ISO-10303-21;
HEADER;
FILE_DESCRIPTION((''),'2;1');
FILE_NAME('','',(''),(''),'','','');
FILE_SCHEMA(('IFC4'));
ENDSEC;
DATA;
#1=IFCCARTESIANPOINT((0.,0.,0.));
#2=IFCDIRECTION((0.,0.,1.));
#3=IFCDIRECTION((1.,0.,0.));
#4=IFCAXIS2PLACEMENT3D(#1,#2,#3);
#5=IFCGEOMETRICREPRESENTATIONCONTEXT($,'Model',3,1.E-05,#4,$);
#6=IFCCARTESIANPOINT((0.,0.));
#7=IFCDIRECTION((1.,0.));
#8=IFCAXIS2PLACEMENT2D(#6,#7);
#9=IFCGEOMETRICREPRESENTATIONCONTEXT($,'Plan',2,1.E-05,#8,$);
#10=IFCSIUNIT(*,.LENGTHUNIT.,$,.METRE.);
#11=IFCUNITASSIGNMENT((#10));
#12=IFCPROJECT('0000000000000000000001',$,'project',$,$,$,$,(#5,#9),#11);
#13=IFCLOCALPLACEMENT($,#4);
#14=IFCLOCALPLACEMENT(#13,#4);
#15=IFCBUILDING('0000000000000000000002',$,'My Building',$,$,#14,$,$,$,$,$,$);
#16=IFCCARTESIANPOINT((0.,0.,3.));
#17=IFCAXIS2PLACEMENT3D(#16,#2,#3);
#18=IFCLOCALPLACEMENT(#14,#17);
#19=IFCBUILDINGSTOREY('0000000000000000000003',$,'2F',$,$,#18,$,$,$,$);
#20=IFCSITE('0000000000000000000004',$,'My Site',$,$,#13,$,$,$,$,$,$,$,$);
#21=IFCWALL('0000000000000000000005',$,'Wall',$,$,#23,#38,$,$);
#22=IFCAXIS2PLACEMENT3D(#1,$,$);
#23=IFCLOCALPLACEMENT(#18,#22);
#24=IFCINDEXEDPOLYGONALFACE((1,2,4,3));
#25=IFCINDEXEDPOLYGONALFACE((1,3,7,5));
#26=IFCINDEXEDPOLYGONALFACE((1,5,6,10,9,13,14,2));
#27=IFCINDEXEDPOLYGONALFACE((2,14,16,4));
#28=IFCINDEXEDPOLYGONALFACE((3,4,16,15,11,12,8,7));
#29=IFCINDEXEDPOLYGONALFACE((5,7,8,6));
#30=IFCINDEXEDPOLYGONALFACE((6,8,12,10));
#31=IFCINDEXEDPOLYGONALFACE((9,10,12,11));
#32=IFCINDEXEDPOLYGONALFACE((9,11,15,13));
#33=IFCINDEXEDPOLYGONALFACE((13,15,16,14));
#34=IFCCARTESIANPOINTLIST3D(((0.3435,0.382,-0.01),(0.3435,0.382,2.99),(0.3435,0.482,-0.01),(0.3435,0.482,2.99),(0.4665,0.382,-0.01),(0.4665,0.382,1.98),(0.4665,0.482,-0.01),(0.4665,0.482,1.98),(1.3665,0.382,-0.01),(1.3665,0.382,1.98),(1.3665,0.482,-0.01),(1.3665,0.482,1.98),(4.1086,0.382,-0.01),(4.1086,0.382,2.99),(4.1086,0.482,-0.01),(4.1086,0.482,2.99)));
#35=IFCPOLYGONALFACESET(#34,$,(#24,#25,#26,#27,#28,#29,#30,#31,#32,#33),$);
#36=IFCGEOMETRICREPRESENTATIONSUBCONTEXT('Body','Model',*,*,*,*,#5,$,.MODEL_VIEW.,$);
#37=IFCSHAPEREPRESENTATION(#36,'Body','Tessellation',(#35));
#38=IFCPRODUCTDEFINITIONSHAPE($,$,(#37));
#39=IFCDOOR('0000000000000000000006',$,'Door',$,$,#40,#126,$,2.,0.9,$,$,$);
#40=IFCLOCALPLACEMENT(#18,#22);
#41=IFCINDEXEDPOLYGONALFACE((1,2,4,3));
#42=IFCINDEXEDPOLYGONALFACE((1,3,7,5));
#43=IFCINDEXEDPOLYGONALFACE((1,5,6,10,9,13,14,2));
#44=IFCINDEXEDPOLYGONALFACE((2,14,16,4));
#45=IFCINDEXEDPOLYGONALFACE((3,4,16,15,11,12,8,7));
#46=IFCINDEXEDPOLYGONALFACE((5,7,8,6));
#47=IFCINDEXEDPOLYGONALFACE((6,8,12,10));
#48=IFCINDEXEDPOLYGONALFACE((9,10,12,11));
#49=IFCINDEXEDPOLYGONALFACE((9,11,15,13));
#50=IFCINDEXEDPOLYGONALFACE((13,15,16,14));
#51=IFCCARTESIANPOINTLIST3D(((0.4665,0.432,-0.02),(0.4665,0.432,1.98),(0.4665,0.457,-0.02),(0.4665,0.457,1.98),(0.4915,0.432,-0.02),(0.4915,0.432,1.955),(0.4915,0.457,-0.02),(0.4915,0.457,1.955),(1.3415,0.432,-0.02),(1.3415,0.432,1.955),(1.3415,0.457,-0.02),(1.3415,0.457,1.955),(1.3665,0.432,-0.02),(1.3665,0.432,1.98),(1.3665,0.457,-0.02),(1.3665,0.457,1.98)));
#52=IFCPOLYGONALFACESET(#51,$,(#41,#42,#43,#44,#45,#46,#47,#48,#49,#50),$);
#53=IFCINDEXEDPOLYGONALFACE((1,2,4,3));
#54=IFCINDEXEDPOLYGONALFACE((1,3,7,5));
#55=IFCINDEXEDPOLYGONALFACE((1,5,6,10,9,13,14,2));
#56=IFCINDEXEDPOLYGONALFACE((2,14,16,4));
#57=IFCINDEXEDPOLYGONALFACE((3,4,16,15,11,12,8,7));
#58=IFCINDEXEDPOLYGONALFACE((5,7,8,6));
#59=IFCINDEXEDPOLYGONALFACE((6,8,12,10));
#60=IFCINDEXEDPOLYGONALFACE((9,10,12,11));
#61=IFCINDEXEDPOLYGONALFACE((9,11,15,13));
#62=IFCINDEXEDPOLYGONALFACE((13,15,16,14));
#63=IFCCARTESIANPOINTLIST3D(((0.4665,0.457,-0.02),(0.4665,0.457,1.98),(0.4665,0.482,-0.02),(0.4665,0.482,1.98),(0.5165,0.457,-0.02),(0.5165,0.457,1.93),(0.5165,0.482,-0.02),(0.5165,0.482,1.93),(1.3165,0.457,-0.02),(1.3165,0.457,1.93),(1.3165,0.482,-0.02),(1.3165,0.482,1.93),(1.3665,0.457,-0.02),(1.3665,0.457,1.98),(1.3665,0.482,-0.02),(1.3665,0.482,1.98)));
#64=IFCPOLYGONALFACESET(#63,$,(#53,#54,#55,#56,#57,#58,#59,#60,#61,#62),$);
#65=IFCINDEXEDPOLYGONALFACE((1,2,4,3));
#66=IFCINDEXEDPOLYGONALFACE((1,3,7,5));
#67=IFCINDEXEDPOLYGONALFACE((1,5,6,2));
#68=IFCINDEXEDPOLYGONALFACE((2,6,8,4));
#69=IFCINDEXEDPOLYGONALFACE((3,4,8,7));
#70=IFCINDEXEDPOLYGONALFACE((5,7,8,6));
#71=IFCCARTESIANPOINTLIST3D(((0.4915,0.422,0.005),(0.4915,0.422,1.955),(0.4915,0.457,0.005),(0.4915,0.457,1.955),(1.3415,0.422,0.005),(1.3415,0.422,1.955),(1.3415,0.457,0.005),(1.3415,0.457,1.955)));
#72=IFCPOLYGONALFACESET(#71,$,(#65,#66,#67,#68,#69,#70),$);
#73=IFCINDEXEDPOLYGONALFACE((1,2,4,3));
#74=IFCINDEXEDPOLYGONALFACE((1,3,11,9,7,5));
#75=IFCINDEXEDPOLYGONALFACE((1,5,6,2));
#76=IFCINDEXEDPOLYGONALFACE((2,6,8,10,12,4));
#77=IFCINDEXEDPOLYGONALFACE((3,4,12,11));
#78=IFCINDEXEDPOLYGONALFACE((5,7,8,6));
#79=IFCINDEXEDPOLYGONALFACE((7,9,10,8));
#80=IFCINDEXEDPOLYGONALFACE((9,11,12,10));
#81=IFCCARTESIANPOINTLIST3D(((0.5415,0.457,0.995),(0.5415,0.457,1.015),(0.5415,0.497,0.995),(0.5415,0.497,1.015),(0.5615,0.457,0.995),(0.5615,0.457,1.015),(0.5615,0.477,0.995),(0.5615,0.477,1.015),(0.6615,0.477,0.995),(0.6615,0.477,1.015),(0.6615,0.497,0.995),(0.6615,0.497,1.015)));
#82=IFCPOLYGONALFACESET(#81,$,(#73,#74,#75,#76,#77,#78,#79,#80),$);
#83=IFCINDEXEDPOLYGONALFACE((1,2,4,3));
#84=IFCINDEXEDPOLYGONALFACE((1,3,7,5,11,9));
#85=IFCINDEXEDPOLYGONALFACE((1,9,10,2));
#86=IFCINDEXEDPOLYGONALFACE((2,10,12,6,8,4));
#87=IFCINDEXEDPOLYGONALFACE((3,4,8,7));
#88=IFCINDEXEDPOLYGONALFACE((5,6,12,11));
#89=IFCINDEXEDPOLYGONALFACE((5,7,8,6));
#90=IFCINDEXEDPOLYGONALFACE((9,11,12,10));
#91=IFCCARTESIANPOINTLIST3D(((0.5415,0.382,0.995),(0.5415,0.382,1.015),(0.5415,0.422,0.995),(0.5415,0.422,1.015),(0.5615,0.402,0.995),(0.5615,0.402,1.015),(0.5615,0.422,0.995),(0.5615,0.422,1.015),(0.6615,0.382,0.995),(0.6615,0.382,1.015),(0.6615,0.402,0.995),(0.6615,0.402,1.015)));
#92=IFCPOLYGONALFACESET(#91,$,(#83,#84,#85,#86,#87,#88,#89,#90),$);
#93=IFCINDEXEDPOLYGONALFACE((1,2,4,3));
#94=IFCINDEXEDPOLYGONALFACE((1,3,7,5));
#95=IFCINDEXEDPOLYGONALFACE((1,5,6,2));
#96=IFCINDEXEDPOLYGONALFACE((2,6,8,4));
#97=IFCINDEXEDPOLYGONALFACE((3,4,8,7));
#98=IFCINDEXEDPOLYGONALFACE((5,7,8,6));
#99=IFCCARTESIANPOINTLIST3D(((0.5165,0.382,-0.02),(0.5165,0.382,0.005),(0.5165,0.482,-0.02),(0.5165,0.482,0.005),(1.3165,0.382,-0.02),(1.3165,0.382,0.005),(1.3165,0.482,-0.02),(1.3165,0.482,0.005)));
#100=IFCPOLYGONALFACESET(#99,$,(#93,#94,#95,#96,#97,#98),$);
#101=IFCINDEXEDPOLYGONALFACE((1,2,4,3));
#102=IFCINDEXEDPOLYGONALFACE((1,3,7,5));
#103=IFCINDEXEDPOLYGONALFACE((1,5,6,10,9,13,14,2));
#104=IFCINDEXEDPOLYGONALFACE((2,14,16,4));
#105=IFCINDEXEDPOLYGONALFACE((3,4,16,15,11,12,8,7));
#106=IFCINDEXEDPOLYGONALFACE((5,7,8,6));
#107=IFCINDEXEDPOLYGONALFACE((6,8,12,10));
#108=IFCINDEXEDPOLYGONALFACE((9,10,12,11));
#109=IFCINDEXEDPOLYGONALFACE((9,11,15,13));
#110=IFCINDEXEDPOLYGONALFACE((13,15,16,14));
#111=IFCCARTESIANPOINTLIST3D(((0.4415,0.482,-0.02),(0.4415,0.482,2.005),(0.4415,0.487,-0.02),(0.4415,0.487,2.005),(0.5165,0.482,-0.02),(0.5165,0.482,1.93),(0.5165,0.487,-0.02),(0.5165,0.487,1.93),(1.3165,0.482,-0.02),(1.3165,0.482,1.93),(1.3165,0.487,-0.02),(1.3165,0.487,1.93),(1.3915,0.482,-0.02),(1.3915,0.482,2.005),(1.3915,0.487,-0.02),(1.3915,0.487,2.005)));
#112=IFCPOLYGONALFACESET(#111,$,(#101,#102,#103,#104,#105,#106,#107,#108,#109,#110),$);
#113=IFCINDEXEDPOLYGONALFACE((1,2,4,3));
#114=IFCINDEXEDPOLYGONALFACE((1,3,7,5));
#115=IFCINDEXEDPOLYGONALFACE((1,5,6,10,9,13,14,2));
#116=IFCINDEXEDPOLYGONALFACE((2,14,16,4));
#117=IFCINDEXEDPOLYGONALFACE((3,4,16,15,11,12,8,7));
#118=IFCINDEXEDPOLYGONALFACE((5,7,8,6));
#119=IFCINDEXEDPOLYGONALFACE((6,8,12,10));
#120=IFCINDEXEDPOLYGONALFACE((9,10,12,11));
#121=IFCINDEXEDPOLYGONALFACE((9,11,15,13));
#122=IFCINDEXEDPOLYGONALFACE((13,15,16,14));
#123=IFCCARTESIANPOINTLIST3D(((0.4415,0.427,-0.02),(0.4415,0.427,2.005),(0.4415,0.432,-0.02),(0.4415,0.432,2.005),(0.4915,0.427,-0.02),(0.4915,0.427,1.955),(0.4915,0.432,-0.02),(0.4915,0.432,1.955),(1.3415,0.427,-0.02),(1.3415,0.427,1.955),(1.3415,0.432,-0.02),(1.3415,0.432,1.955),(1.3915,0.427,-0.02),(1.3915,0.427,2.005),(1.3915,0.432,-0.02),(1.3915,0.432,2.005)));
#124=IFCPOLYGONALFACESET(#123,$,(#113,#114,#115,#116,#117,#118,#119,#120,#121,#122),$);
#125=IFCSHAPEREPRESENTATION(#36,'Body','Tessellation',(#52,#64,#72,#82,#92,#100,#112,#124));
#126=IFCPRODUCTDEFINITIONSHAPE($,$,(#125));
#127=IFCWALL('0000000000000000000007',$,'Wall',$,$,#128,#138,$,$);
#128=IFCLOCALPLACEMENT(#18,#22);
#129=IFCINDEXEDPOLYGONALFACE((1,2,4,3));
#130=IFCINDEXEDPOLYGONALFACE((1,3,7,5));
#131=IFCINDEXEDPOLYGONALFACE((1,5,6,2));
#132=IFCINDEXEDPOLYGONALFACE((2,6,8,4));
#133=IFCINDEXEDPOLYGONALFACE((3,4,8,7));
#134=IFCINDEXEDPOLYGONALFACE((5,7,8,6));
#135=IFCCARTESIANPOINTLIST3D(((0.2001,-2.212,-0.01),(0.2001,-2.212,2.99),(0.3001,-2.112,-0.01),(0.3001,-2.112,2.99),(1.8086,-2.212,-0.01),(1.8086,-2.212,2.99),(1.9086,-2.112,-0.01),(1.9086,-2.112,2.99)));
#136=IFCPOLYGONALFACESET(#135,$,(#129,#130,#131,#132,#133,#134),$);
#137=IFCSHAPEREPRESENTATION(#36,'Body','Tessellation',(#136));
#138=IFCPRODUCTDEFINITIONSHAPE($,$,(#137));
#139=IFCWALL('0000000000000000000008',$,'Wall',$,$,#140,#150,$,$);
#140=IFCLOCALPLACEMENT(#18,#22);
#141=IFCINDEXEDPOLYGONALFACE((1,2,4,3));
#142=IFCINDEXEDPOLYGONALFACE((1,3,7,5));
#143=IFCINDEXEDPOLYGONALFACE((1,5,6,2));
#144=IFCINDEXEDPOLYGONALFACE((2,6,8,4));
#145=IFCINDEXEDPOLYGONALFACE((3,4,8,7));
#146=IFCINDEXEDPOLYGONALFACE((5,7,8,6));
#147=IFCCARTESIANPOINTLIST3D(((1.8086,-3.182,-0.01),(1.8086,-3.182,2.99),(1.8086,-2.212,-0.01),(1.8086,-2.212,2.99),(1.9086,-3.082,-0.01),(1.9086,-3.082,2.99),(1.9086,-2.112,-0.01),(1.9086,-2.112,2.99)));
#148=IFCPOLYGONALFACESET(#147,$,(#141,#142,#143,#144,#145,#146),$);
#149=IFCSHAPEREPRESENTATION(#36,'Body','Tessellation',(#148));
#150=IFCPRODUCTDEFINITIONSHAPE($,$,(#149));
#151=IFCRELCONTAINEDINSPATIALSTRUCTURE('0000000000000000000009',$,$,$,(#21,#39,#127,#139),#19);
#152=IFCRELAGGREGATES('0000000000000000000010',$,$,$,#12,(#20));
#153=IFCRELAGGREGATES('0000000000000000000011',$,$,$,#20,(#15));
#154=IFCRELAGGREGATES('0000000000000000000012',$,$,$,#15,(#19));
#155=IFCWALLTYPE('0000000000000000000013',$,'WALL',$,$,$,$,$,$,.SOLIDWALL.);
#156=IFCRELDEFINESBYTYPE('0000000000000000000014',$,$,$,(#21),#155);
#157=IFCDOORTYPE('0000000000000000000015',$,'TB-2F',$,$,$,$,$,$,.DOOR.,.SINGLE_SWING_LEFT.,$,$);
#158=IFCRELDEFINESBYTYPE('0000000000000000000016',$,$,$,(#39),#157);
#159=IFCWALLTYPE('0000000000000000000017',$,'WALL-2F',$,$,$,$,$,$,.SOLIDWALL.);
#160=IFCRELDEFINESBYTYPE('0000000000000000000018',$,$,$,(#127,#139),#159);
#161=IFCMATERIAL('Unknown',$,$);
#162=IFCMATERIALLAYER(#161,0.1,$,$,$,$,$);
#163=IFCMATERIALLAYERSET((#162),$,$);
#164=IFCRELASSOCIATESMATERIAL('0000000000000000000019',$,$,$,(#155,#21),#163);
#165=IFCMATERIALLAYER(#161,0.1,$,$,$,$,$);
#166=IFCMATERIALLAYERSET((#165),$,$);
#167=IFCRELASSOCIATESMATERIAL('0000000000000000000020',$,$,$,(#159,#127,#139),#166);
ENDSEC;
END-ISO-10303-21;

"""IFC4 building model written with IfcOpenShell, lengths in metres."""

from ifc_helpers import new_model, entity, si_unit, frame, origin_with_axes, origin_2d_with_axis, place, context, subcontext, project, spatial, line, indexed_curve, outline, extrude, shape, source, transform, mapped, material, layer, layer_set, layer_usage, type_object, type_shapes, element, fill, save


model = new_model("IFC4")

# Units and contexts
model_context = context("Model", 3, precision=1e-05, world=origin_with_axes())
plan_context = context("Plan", 2, precision=1e-05, world=origin_2d_with_axis())
body_context_1 = subcontext(model_context, "Body", "Model", "MODEL_VIEW")
body_context_2 = subcontext(plan_context, "Body", "Plan", "PLAN_VIEW")
ifc_project = project(units=[si_unit("LENGTHUNIT", "METRE")], contexts=[model_context, plan_context])

# Site, building, storey
site_placement = place(None, origin_with_axes())
site = spatial("IfcSite", under=ifc_project, at=site_placement, Name="My Site")
building_placement = place(site_placement, origin_with_axes())
building = spatial("IfcBuilding", under=site, at=building_placement, Name="My Building")
storey_placement = place(building_placement, frame((0.0, 0.0, 3.0), z_axis=(0.0, 0.0, 1.0), x_axis=(1.0, 0.0, 0.0)))
storey = spatial("IfcBuildingStorey", under=building, at=storey_placement, Name="2F")

# Shared definitions
ifc_material_1 = material(Name="Unknown")

# Wall, opening, door
ifc_layer_1 = layer(ifc_material_1, 0.1)
ifc_layer_set_1 = layer_set([ifc_layer_1])
ifc_layer_usage_1 = layer_usage(ifc_layer_set_1, "AXIS2", "POSITIVE", 0.0)
wall_type_1 = type_object("IfcWallType", Name="WALL", PredefinedType="SOLIDWALL", material=ifc_layer_set_1)
wall_1_placement = place(storey_placement, frame((0.3435, 0.382, -0.01), z_axis=(0.0, 0.0, 1.0), x_axis=(1.0, 0.0, 0.0)))
wall_1 = element("IfcWall", 1, at=wall_1_placement, inside=storey, type_object=wall_type_1, material=ifc_layer_usage_1, Name="Wall", context=body_context_1, shape_type="SweptSolid", body=[
    extrude(outline(indexed_curve([(0.0, 0.0), (0.0, 0.1), (3.7651, 0.1), (3.7651, 0.0)], segments=[line(1, 2, 3, 4, 1)])), origin_with_axes(), (0.0, 0.0, 1.0), 3.0),
])
shared_shape_1 = source(origin_with_axes(), body_context_1, "Body", "SweptSolid", [
    extrude(outline(indexed_curve([(0.0, 0.0), (0.9, 0.0), (0.9, 2.0), (0.0, 2.0)], segments=[line(1, 2, 3, 4, 1)])), frame((0.0, -0.6, 0.0), z_axis=(0.0, -1.0, 0.0), x_axis=(1.0, 0.0, 0.0)), (0.0, 0.0, -1.0), 1.2),
])
opening_1_placement = place(wall_1_placement, frame((1.023, 0.1, -0.01), z_axis=(0.0, 0.0, 1.0), x_axis=(-1.0, 0.0, 0.0)))
opening_1 = element("IfcOpeningElement", 2, at=opening_1_placement, cuts=wall_1, PredefinedType="OPENING", context=body_context_1, shape_type="MappedRepresentation", body=[
    mapped(shared_shape_1, transform((0.0, 0.0, 0.0), x_axis=(1.0, 0.0, 0.0), y_axis=(0.0, 1.0, 0.0), z_axis=(0.0, 0.0, 1.0), scale=1.0)),
])
door_type_1 = type_object("IfcDoorType", Name="TB-2F", OperationType="SINGLE_SWING_LEFT", PredefinedType="DOOR")
shared_shape_2 = source(origin_with_axes(), body_context_1, "Body", "SweptSolid", [
    extrude(outline(indexed_curve([(0.0, 0.0), (0.0, 2.0), (0.9, 2.0), (0.9, 0.0), (0.875, 0.0), (0.875, 1.975), (0.025, 1.975), (0.025, 0.0)], segments=[line(1, 2, 3, 4, 5, 6, 7, 8, 1)])), frame((0.0, 0.025, 0.0), z_axis=(0.0, -1.0, 0.0), x_axis=(1.0, 0.0, 0.0)), (0.0, 0.0, -1.0), 0.025),
    extrude(outline(indexed_curve([(0.0, 0.0), (0.0, 2.0), (0.9, 2.0), (0.9, 0.0), (0.85, 0.0), (0.85, 1.95), (0.05, 1.95), (0.05, 0.0)], segments=[line(1, 2, 3, 4, 5, 6, 7, 8, 1)])), frame((0.0, 0.0, 0.0), z_axis=(0.0, -1.0, 0.0), x_axis=(1.0, 0.0, 0.0)), (0.0, 0.0, -1.0), 0.025),
    extrude(outline(indexed_curve([(0.0, 0.0), (0.85, 0.0), (0.85, 0.035), (0.0, 0.035)], segments=[line(1, 2, 3, 4, 1)])), frame((0.025, 0.025, 0.025), z_axis=(0.0, 0.0, 1.0), x_axis=(1.0, 0.0, 0.0)), (0.0, 0.0, 1.0), 1.95),
    extrude(outline(indexed_curve([(0.0, 0.0), (0.0, -0.04), (-0.12, -0.04), (-0.12, -0.02), (-0.02, -0.02), (-0.02, 0.0)], segments=[line(1, 2, 3, 4, 5, 6, 1)])), frame((0.825, 0.025, 1.015), z_axis=(0.0, 0.0, 1.0), x_axis=(1.0, 0.0, 0.0)), (0.0, 0.0, 1.0), 0.02),
    extrude(outline(indexed_curve([(0.0, 0.0), (0.0, 0.04), (-0.12, 0.04), (-0.12, 0.02), (-0.02, 0.02), (-0.02, 0.0)], segments=[line(1, 2, 3, 4, 5, 6, 1)])), frame((0.825, 0.06, 1.015), z_axis=(0.0, 0.0, 1.0), x_axis=(1.0, 0.0, 0.0)), (0.0, 0.0, 1.0), 0.02),
    extrude(outline(indexed_curve([(0.0, 0.0), (0.8, 0.0), (0.8, 0.1), (0.0, 0.1)], segments=[line(1, 2, 3, 4, 1)])), frame((0.05, 0.0, 0.0), z_axis=(0.0, 0.0, 1.0), x_axis=(1.0, 0.0, 0.0)), (0.0, 0.0, 1.0), 0.025),
    extrude(outline(indexed_curve([(0.0, 0.0), (0.0, 2.025), (0.95, 2.025), (0.95, 0.0), (0.875, 0.0), (0.875, 1.95), (0.075, 1.95), (0.075, 0.0)], segments=[line(1, 2, 3, 4, 5, 6, 7, 8, 1)])), frame((-0.025, -0.005, 0.0), z_axis=(0.0, -1.0, 0.0), x_axis=(1.0, 0.0, 0.0)), (0.0, 0.0, -1.0), 0.005),
    extrude(outline(indexed_curve([(0.0, 0.0), (0.0, 2.025), (0.95, 2.025), (0.95, 0.0), (0.9, 0.0), (0.9, 1.975), (0.05, 1.975), (0.05, 0.0)], segments=[line(1, 2, 3, 4, 5, 6, 7, 8, 1)])), frame((-0.025, 0.05, 0.0), z_axis=(0.0, -1.0, 0.0), x_axis=(1.0, 0.0, 0.0)), (0.0, 0.0, -1.0), 0.005),
])
shared_shape_3 = source(origin_with_axes(), body_context_2, "Body", "Curve2D", [
    entity("IfcIndexedPolyCurve", entity("IfcCartesianPointList2D", [[0.0, 0.0], [0.0, 0.05], [0.025, 0.05], [0.025, 0.025], [0.05, 0.025], [0.05, 0.0]]), [entity("IfcLineIndex", [1, 2, 3, 4, 5, 6, 1])]),
    entity("IfcIndexedPolyCurve", entity("IfcCartesianPointList2D", [[0.9, 0.0], [0.9, 0.05], [0.875, 0.05], [0.875, 0.025], [0.85, 0.025], [0.85, 0.0]]), [entity("IfcLineIndex", [1, 2, 3, 4, 5, 6, 1])]),
    entity("IfcTrimmedCurve", entity("IfcEllipse", entity("IfcAxis2Placement2D", entity("IfcCartesianPoint", [0.06, 0.05]), entity("IfcDirection", [1.0, 0.0])), 0.815, 0.85), [entity("IfcCartesianPoint", [0.875, 0.05])], [entity("IfcCartesianPoint", [0.06, 0.9])], True, "CARTESIAN"),
    entity("IfcIndexedPolyCurve", entity("IfcCartesianPointList2D", [[0.025, 0.05], [0.06, 0.05], [0.06, 0.9], [0.025, 0.9]]), [entity("IfcLineIndex", [1, 2, 3, 4, 1])]),
])
type_shapes(door_type_1, [shared_shape_2, shared_shape_3])
door_1_placement = place(opening_1_placement, frame((0.0, 0.0, 0.0), z_axis=(0.0, 0.0, 1.0), x_axis=(1.0, 0.0, 0.0)))
door_1 = element("IfcDoor", 3, at=door_1_placement, inside=storey, type_object=door_type_1, Name="Door", OverallHeight=2.0, OverallWidth=0.9, shapes=[
    shape(body_context_1, "Body", "MappedRepresentation", [mapped(shared_shape_2, transform((0.0, 0.0, 0.0), x_axis=(1.0, 0.0, 0.0), y_axis=(0.0, 1.0, 0.0), z_axis=(0.0, 0.0, 1.0), scale=1.0))]),
    shape(body_context_2, "Body", "MappedRepresentation", [mapped(shared_shape_3, transform((0.0, 0.0, 0.0), x_axis=(1.0, 0.0, 0.0), y_axis=(0.0, 1.0, 0.0), z_axis=(0.0, 0.0, 1.0), scale=1.0))]),
])
fill(opening_1, door_1)

# Walls
ifc_layer_2 = layer(ifc_material_1, 0.1)
ifc_layer_set_2 = layer_set([ifc_layer_2])
ifc_layer_usage_2 = layer_usage(ifc_layer_set_2, "AXIS2", "POSITIVE", 0.0)
wall_type_2 = type_object("IfcWallType", Name="WALL-2F", PredefinedType="SOLIDWALL", material=ifc_layer_set_2)
wall_2_placement = place(storey_placement, frame((0.2001, -2.212, -0.01), z_axis=(0.0, 0.0, 1.0), x_axis=(1.0, 0.0, 0.0)))
element("IfcWall", 4, at=wall_2_placement, inside=storey, type_object=wall_type_2, material=ifc_layer_usage_2, Name="Wall", context=body_context_1, shape_type="SweptSolid", body=[
    extrude(outline(indexed_curve([(0.0, 0.0), (0.1, 0.1), (1.7085, 0.1), (1.6085, 0.0)], segments=[line(1, 2, 3, 4, 1)])), origin_with_axes(), (0.0, 0.0, 1.0), 3.0),
])
ifc_layer_usage_3 = layer_usage(ifc_layer_set_2, "AXIS2", "POSITIVE", 0.0)
wall_3_placement = place(storey_placement, frame((1.8086, -2.212, -0.01), z_axis=(0.0, 0.0, 1.0), x_axis=(0.0, -1.0, 0.0)))
element("IfcWall", 5, at=wall_3_placement, inside=storey, type_object=wall_type_2, material=ifc_layer_usage_3, Name="Wall", context=body_context_1, shape_type="SweptSolid", body=[
    extrude(outline(indexed_curve([(0.0, 0.0), (-0.1, 0.1), (0.87, 0.1), (0.97, 0.0)], segments=[line(1, 2, 3, 4, 1)])), origin_with_axes(), (0.0, 0.0, 1.0), 3.0),
])

save(model, "model.ifc")
